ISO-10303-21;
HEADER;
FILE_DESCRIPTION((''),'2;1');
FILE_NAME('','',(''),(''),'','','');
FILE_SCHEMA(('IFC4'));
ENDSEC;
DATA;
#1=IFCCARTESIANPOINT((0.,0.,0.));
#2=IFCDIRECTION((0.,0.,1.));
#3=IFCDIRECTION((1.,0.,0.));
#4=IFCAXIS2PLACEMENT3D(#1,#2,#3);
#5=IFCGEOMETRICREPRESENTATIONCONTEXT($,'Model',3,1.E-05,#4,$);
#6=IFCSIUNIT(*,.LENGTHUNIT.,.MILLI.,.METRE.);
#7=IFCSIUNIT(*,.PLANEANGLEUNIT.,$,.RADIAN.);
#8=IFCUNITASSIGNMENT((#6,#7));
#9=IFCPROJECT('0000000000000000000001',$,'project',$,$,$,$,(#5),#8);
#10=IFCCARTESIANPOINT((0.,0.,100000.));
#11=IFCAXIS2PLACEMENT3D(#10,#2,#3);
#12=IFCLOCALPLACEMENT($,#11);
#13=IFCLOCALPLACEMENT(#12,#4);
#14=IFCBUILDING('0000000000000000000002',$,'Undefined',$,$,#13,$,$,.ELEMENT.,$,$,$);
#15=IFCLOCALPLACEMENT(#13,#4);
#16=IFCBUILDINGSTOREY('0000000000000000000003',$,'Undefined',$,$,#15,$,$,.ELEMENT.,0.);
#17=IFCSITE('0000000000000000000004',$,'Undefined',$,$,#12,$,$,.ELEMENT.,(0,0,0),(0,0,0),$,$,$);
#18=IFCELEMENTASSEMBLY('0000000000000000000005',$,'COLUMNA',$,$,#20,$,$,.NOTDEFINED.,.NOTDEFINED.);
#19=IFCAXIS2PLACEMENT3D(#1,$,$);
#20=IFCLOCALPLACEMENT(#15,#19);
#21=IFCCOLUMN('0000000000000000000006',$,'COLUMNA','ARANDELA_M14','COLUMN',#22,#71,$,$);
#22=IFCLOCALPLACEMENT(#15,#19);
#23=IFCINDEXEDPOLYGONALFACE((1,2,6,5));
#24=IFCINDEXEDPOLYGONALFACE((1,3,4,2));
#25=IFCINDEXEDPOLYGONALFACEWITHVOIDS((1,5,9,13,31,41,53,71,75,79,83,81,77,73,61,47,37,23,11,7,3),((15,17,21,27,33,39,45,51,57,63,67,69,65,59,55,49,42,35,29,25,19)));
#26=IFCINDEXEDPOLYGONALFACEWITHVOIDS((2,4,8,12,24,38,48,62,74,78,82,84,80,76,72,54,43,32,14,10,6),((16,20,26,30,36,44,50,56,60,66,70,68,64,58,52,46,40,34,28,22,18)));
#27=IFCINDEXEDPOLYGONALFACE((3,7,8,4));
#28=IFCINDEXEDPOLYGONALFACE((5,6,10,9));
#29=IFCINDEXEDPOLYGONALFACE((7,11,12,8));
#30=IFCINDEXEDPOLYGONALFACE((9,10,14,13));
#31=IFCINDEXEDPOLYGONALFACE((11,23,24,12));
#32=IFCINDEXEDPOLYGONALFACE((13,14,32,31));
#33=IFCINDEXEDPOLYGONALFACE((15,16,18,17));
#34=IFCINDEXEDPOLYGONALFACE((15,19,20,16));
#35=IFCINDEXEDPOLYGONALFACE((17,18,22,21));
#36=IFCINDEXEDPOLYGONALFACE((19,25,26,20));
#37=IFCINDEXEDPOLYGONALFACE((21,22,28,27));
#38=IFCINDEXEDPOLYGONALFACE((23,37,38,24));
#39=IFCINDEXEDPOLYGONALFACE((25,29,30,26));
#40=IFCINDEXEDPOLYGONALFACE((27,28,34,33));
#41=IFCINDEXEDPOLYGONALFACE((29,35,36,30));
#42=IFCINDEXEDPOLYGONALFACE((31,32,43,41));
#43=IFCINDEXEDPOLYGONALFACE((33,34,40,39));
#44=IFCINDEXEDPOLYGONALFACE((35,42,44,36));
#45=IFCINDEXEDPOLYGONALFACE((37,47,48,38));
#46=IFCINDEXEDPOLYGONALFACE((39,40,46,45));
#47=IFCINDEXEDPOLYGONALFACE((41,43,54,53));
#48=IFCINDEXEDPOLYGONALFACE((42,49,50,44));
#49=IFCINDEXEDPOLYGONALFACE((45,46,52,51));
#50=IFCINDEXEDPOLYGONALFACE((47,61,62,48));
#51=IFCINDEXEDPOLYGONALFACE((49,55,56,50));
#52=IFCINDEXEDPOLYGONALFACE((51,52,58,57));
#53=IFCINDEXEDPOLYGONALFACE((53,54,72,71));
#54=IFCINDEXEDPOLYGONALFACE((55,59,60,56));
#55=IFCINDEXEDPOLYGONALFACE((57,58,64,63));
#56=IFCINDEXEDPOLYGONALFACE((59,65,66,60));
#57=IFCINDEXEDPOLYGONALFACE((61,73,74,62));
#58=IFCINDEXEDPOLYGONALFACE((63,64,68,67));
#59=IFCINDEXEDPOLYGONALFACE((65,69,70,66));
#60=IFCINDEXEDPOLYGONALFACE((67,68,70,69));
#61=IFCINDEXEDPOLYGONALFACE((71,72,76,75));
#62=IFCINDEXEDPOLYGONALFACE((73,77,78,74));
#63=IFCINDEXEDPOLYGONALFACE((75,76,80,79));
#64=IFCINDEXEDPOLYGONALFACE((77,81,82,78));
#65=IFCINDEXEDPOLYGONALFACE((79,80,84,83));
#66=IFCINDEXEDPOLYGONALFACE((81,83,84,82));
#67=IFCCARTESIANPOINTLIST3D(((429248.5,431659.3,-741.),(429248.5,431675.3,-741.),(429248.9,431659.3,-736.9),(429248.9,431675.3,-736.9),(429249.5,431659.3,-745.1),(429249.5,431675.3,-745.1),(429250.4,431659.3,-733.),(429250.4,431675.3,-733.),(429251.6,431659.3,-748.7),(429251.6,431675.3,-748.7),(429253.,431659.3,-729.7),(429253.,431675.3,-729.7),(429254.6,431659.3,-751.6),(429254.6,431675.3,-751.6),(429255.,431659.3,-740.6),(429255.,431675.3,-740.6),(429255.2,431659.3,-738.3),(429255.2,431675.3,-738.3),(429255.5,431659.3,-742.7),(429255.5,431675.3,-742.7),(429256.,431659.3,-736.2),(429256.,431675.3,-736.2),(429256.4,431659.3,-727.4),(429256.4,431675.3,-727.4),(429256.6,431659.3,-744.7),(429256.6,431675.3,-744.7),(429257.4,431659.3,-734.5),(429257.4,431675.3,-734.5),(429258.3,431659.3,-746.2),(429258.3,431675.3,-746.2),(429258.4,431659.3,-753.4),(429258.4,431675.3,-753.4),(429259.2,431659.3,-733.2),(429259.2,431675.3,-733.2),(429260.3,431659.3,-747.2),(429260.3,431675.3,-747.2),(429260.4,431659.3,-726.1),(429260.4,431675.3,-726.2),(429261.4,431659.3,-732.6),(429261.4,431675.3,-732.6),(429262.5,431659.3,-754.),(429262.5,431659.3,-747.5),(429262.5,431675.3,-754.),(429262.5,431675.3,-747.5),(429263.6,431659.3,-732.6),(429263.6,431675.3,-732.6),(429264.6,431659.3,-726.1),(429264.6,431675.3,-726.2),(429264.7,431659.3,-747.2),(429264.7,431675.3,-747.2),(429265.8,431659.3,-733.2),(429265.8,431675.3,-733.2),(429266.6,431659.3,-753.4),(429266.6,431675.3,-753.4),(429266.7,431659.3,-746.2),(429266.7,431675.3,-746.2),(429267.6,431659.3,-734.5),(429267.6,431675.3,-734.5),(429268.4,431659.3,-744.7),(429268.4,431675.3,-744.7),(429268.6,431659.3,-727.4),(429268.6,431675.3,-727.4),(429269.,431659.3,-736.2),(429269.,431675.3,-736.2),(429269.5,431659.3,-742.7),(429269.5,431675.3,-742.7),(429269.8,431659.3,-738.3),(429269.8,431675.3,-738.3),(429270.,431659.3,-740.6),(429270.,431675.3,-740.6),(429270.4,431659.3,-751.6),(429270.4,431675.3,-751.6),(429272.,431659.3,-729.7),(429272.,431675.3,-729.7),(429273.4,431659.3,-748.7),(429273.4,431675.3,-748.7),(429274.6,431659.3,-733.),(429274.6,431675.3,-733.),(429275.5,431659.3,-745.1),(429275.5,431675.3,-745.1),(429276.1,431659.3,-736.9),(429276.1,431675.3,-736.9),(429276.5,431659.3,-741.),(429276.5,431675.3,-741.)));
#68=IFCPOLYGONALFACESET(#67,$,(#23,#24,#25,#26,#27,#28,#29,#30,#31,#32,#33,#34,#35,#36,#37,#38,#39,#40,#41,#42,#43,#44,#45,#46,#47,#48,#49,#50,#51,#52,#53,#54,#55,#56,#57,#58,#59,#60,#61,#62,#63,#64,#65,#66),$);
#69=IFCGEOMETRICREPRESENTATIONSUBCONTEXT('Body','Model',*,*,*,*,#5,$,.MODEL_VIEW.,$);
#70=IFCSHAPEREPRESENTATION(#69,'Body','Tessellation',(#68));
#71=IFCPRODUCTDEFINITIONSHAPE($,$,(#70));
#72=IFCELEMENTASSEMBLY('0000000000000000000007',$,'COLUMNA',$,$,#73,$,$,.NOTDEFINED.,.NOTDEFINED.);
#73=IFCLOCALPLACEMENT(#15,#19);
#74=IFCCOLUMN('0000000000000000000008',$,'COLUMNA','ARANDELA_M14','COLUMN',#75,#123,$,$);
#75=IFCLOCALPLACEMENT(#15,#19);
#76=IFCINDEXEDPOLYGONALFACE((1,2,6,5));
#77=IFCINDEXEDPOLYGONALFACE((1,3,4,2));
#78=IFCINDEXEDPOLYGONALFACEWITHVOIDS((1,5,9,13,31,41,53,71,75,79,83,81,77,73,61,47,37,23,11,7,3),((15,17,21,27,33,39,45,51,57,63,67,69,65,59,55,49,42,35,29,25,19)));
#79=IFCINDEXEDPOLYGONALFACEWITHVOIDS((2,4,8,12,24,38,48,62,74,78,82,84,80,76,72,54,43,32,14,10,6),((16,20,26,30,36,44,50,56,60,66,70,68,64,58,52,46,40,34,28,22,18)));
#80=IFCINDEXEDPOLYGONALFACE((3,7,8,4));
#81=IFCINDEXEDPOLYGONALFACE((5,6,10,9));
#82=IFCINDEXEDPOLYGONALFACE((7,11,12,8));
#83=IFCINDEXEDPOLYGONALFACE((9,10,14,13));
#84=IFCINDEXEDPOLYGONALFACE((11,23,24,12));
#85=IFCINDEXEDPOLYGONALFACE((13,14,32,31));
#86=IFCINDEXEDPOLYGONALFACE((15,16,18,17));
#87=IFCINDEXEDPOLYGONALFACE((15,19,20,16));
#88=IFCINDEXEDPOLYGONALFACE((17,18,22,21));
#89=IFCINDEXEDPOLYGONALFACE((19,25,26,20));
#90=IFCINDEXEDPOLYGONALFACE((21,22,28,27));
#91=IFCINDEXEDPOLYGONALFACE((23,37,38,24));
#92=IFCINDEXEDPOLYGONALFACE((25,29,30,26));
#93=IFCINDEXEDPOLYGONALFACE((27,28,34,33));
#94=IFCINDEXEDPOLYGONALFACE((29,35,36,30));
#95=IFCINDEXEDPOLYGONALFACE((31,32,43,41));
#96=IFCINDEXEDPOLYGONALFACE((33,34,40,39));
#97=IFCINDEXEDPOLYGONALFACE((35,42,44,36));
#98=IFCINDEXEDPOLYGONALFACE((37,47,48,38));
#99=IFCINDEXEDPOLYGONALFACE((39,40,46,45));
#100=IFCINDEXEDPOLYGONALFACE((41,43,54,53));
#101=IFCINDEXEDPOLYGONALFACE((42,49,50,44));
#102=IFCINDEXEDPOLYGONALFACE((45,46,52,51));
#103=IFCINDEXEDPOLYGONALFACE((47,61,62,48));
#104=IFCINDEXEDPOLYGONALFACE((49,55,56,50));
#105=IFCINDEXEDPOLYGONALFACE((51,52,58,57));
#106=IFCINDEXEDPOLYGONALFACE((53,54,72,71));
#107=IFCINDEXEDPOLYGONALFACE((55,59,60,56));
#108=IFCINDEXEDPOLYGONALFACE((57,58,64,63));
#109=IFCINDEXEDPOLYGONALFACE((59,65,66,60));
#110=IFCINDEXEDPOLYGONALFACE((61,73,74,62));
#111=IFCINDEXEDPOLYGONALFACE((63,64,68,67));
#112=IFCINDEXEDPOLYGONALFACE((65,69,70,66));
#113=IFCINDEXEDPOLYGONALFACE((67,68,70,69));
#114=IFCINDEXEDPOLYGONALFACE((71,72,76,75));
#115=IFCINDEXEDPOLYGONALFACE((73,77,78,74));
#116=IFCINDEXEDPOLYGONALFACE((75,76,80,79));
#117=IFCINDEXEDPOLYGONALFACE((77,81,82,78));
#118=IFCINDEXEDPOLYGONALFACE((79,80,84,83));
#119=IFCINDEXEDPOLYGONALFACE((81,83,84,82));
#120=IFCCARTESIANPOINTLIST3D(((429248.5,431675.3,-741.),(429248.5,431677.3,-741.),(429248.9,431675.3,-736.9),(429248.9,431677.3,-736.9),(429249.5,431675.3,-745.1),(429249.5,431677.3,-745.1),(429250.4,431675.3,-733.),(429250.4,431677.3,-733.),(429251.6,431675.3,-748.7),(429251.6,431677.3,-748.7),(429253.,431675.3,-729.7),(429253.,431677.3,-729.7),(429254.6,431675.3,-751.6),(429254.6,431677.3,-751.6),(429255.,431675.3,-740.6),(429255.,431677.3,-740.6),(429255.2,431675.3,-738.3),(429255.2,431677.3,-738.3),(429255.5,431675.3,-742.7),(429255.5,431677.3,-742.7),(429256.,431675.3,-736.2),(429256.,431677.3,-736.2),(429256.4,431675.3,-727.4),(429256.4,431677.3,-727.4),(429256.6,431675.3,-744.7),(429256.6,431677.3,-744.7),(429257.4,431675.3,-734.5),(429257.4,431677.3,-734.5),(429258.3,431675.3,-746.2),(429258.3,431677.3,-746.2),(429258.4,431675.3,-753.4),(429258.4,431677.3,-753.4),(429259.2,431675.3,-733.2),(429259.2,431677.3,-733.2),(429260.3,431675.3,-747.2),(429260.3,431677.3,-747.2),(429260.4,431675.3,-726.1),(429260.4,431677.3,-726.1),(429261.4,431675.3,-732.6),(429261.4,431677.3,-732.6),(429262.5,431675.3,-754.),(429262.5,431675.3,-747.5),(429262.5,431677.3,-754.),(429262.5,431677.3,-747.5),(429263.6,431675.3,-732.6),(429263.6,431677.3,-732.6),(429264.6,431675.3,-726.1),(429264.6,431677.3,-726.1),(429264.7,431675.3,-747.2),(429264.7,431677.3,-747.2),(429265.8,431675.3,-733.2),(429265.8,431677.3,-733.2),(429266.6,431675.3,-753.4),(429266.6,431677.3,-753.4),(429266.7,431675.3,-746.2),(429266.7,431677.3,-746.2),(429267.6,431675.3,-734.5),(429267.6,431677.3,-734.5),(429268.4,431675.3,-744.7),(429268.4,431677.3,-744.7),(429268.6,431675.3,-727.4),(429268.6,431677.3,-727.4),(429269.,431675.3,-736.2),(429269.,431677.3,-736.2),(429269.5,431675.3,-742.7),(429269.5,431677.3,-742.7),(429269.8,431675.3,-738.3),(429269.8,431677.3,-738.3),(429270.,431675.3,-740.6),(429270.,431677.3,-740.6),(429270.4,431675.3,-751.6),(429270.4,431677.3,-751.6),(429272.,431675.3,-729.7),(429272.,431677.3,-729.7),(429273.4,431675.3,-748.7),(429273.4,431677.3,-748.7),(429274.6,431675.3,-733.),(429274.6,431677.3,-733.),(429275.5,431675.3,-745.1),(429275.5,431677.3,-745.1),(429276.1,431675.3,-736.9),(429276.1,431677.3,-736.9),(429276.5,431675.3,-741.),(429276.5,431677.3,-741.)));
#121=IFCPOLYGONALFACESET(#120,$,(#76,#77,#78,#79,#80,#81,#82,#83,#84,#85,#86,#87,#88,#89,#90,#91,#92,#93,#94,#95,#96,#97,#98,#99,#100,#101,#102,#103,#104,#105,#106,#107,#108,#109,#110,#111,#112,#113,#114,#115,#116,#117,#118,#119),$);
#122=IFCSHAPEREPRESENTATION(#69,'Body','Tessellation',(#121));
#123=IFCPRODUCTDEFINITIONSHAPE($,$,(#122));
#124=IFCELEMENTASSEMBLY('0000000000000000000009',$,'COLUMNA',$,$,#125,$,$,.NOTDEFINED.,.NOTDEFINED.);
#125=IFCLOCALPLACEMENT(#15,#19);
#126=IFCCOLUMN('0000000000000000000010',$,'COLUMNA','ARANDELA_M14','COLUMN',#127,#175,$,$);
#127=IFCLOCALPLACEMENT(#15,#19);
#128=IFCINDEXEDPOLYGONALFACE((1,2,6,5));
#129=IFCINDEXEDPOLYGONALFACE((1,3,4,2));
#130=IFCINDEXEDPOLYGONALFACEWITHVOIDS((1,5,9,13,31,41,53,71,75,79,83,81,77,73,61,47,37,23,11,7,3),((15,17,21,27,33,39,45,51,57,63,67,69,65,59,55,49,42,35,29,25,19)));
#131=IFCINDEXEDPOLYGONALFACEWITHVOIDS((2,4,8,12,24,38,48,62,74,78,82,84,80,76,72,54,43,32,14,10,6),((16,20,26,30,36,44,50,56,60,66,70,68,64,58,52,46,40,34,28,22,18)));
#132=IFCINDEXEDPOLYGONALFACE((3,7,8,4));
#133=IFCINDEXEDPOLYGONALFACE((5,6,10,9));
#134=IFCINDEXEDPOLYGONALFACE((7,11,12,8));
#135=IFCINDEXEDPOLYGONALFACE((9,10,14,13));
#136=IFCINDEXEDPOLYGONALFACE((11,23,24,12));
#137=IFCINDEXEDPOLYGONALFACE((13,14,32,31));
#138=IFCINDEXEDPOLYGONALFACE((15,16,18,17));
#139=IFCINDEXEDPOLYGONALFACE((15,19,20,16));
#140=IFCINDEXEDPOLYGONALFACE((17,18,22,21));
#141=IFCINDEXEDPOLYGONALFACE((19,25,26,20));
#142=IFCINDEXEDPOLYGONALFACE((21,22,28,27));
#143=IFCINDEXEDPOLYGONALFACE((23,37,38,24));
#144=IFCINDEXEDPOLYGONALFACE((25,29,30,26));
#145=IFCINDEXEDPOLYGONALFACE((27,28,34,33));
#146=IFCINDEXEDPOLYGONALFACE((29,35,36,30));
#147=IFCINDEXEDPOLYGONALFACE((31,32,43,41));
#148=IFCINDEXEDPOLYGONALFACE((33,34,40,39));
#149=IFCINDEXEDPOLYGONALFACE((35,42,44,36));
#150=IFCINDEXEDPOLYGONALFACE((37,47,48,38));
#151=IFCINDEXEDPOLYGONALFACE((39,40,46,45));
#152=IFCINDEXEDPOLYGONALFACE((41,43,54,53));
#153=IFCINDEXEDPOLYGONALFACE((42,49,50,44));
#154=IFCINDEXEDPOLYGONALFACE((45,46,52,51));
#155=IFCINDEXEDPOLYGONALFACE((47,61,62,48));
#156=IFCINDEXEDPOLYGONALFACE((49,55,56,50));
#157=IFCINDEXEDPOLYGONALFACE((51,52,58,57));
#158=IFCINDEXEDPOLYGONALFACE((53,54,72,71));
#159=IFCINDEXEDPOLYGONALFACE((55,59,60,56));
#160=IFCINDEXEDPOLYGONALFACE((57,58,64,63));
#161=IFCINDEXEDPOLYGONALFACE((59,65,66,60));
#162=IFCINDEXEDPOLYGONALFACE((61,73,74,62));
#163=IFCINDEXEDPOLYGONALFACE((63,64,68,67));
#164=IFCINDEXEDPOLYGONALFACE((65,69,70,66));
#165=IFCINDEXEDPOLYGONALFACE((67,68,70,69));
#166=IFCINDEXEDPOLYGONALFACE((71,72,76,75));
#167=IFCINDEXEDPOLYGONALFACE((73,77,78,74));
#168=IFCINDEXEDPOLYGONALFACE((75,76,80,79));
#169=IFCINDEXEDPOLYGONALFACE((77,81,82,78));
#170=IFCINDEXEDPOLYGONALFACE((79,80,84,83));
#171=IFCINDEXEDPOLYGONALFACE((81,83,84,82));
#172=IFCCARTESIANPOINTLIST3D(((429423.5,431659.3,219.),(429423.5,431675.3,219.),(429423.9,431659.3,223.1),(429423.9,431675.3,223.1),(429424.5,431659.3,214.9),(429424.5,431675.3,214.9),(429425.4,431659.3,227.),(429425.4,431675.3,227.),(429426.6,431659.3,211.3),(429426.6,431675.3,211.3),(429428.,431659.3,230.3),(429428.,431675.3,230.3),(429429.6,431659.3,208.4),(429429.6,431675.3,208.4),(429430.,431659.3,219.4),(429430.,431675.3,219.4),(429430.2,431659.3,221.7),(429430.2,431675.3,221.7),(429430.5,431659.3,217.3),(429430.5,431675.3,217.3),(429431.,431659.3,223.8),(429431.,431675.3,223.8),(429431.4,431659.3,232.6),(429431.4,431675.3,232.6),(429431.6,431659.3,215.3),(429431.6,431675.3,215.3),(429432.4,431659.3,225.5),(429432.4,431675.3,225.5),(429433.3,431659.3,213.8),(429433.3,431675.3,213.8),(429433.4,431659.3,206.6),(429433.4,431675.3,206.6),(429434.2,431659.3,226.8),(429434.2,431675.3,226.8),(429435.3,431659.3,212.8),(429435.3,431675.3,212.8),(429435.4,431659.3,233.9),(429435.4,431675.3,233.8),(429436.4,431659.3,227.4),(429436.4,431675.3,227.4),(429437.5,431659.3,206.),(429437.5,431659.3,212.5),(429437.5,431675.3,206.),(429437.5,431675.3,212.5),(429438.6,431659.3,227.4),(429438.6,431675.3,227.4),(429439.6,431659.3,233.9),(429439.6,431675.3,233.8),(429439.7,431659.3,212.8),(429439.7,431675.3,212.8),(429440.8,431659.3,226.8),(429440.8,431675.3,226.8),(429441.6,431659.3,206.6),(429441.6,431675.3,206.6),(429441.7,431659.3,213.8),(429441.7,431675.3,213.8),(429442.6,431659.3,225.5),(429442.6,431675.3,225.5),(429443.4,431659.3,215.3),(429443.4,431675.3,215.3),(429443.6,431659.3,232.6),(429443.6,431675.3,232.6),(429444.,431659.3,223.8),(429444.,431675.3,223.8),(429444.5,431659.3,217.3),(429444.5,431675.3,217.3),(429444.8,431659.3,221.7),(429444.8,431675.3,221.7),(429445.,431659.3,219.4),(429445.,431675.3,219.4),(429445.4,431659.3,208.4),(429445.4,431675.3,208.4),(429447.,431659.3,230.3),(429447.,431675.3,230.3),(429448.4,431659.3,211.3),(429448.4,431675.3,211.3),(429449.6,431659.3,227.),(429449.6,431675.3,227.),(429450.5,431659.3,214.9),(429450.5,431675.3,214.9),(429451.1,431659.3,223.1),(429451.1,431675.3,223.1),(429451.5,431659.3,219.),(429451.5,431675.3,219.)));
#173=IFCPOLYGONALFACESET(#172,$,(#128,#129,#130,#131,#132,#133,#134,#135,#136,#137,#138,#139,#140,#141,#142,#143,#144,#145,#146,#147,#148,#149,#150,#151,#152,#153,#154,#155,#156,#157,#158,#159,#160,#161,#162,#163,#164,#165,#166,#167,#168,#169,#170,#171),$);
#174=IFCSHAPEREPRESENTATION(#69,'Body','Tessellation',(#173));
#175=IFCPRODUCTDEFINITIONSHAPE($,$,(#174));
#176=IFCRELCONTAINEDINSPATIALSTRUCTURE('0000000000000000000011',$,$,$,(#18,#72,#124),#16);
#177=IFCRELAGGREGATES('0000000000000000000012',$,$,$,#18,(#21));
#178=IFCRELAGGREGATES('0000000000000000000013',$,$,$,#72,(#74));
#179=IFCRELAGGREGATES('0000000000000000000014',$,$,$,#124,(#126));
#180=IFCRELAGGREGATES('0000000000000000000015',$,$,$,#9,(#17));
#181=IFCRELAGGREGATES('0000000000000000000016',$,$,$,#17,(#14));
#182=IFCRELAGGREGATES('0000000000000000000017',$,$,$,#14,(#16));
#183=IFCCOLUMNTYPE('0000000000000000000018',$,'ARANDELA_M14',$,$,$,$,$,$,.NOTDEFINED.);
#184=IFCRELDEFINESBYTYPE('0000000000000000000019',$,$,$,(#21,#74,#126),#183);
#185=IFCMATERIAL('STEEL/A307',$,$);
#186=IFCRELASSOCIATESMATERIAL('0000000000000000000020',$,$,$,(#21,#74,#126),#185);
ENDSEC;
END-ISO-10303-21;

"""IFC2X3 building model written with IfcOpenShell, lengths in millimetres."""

from ifc_helpers import new_model, si_unit, frame, origin_with_axes, origin_2d_with_axis, place, context, subcontext, project, spatial, hollow_circle, extrude, material, type_object, element, aggregate, save


model = new_model("IFC2X3")

# Units and contexts
model_context = context("Model", 3, precision=1e-05, world=origin_with_axes())
body_context = subcontext(model_context, "Body", "Model", "MODEL_VIEW")
ifc_project = project(units=[si_unit("LENGTHUNIT", "METRE", prefix="MILLI"), si_unit("PLANEANGLEUNIT", "RADIAN")], contexts=[model_context])

# Site, building, storey
site_placement = place(None, frame((0.0, 0.0, 100000.0), z_axis=(0.0, 0.0, 1.0), x_axis=(1.0, 0.0, 0.0)))
site = spatial("IfcSite", under=ifc_project, at=site_placement, Name="Undefined", CompositionType="ELEMENT", RefLatitude=(0, 0, 0), RefLongitude=(0, 0, 0))
building_placement = place(site_placement, origin_with_axes())
building = spatial("IfcBuilding", under=site, at=building_placement, Name="Undefined", CompositionType="ELEMENT")
storey_placement = place(building_placement, origin_with_axes())
storey = spatial("IfcBuildingStorey", under=building, at=storey_placement, Name="Undefined", CompositionType="ELEMENT", Elevation=0.0)

# Element assemblies, columns
ifc_material_1 = material(Name="STEEL/A307")
column_type_1 = type_object("IfcColumnType", Name="ARANDELA_M14", PredefinedType="NOTDEFINED")
assembly_1_placement = place(storey_placement, origin_with_axes())
assembly_1 = element("IfcElementAssembly", 1, at=assembly_1_placement, inside=storey, Name="COLUMNA", AssemblyPlace="NOTDEFINED", PredefinedType="NOTDEFINED")
column_1_placement = place(assembly_1_placement, frame((429262.5, 431675.3, -740.0), z_axis=(0.0, -1.0, 0.000285), x_axis=(-1.0, 0.0, 0.0)))
column_1 = element("IfcColumn", 2, at=column_1_placement, type_object=column_type_1, material=ifc_material_1, Name="COLUMNA", Description="ARANDELA_M14", ObjectType="COLUMN", context=body_context, shape_type="SweptSolid", body=[
    extrude(hollow_circle(Radius=14.0, WallThickness=6.5, at=origin_2d_with_axis()), frame((0.0, 0.0, 16.0), z_axis=(0.0, 0.0, -1.0), x_axis=(0.0, 1.0, 0.0)), (0.0, 0.0, 1.0), 16.0),
])
aggregate(assembly_1, [column_1])
assembly_2_placement = place(storey_placement, origin_with_axes())
assembly_2 = element("IfcElementAssembly", 3, at=assembly_2_placement, inside=storey, Name="COLUMNA", AssemblyPlace="NOTDEFINED", PredefinedType="NOTDEFINED")
column_2_placement = place(assembly_2_placement, frame((429262.5, 431677.3, -740.0), z_axis=(0.0, -1.0, 0.000285), x_axis=(-1.0, 0.0, 0.0)))
column_2 = element("IfcColumn", 4, at=column_2_placement, type_object=column_type_1, material=ifc_material_1, Name="COLUMNA", Description="ARANDELA_M14", ObjectType="COLUMN", context=body_context, shape_type="SweptSolid", body=[
    extrude(hollow_circle(Radius=14.0, WallThickness=6.5, at=origin_2d_with_axis()), frame((0.0, 0.0, 2.0), z_axis=(0.0, 0.0, -1.0), x_axis=(0.0, 1.0, 0.0)), (0.0, 0.0, 1.0), 2.0),
])
aggregate(assembly_2, [column_2])
assembly_3_placement = place(storey_placement, origin_with_axes())
assembly_3 = element("IfcElementAssembly", 5, at=assembly_3_placement, inside=storey, Name="COLUMNA", AssemblyPlace="NOTDEFINED", PredefinedType="NOTDEFINED")
column_3_placement = place(assembly_3_placement, frame((429437.5, 431675.3, 220.0), z_axis=(0.0, -1.0, 0.000285), x_axis=(-1.0, 0.0, 0.0)))
column_3 = element("IfcColumn", 6, at=column_3_placement, type_object=column_type_1, material=ifc_material_1, Name="COLUMNA", Description="ARANDELA_M14", ObjectType="COLUMN", context=body_context, shape_type="SweptSolid", body=[
    extrude(hollow_circle(Radius=14.0, WallThickness=6.5, at=origin_2d_with_axis()), frame((0.0, 0.0, 16.0), z_axis=(0.0, 0.0, -1.0), x_axis=(0.0, 1.0, 0.0)), (0.0, 0.0, 1.0), 16.0),
])
aggregate(assembly_3, [column_3])

save(model, "model.ifc")
